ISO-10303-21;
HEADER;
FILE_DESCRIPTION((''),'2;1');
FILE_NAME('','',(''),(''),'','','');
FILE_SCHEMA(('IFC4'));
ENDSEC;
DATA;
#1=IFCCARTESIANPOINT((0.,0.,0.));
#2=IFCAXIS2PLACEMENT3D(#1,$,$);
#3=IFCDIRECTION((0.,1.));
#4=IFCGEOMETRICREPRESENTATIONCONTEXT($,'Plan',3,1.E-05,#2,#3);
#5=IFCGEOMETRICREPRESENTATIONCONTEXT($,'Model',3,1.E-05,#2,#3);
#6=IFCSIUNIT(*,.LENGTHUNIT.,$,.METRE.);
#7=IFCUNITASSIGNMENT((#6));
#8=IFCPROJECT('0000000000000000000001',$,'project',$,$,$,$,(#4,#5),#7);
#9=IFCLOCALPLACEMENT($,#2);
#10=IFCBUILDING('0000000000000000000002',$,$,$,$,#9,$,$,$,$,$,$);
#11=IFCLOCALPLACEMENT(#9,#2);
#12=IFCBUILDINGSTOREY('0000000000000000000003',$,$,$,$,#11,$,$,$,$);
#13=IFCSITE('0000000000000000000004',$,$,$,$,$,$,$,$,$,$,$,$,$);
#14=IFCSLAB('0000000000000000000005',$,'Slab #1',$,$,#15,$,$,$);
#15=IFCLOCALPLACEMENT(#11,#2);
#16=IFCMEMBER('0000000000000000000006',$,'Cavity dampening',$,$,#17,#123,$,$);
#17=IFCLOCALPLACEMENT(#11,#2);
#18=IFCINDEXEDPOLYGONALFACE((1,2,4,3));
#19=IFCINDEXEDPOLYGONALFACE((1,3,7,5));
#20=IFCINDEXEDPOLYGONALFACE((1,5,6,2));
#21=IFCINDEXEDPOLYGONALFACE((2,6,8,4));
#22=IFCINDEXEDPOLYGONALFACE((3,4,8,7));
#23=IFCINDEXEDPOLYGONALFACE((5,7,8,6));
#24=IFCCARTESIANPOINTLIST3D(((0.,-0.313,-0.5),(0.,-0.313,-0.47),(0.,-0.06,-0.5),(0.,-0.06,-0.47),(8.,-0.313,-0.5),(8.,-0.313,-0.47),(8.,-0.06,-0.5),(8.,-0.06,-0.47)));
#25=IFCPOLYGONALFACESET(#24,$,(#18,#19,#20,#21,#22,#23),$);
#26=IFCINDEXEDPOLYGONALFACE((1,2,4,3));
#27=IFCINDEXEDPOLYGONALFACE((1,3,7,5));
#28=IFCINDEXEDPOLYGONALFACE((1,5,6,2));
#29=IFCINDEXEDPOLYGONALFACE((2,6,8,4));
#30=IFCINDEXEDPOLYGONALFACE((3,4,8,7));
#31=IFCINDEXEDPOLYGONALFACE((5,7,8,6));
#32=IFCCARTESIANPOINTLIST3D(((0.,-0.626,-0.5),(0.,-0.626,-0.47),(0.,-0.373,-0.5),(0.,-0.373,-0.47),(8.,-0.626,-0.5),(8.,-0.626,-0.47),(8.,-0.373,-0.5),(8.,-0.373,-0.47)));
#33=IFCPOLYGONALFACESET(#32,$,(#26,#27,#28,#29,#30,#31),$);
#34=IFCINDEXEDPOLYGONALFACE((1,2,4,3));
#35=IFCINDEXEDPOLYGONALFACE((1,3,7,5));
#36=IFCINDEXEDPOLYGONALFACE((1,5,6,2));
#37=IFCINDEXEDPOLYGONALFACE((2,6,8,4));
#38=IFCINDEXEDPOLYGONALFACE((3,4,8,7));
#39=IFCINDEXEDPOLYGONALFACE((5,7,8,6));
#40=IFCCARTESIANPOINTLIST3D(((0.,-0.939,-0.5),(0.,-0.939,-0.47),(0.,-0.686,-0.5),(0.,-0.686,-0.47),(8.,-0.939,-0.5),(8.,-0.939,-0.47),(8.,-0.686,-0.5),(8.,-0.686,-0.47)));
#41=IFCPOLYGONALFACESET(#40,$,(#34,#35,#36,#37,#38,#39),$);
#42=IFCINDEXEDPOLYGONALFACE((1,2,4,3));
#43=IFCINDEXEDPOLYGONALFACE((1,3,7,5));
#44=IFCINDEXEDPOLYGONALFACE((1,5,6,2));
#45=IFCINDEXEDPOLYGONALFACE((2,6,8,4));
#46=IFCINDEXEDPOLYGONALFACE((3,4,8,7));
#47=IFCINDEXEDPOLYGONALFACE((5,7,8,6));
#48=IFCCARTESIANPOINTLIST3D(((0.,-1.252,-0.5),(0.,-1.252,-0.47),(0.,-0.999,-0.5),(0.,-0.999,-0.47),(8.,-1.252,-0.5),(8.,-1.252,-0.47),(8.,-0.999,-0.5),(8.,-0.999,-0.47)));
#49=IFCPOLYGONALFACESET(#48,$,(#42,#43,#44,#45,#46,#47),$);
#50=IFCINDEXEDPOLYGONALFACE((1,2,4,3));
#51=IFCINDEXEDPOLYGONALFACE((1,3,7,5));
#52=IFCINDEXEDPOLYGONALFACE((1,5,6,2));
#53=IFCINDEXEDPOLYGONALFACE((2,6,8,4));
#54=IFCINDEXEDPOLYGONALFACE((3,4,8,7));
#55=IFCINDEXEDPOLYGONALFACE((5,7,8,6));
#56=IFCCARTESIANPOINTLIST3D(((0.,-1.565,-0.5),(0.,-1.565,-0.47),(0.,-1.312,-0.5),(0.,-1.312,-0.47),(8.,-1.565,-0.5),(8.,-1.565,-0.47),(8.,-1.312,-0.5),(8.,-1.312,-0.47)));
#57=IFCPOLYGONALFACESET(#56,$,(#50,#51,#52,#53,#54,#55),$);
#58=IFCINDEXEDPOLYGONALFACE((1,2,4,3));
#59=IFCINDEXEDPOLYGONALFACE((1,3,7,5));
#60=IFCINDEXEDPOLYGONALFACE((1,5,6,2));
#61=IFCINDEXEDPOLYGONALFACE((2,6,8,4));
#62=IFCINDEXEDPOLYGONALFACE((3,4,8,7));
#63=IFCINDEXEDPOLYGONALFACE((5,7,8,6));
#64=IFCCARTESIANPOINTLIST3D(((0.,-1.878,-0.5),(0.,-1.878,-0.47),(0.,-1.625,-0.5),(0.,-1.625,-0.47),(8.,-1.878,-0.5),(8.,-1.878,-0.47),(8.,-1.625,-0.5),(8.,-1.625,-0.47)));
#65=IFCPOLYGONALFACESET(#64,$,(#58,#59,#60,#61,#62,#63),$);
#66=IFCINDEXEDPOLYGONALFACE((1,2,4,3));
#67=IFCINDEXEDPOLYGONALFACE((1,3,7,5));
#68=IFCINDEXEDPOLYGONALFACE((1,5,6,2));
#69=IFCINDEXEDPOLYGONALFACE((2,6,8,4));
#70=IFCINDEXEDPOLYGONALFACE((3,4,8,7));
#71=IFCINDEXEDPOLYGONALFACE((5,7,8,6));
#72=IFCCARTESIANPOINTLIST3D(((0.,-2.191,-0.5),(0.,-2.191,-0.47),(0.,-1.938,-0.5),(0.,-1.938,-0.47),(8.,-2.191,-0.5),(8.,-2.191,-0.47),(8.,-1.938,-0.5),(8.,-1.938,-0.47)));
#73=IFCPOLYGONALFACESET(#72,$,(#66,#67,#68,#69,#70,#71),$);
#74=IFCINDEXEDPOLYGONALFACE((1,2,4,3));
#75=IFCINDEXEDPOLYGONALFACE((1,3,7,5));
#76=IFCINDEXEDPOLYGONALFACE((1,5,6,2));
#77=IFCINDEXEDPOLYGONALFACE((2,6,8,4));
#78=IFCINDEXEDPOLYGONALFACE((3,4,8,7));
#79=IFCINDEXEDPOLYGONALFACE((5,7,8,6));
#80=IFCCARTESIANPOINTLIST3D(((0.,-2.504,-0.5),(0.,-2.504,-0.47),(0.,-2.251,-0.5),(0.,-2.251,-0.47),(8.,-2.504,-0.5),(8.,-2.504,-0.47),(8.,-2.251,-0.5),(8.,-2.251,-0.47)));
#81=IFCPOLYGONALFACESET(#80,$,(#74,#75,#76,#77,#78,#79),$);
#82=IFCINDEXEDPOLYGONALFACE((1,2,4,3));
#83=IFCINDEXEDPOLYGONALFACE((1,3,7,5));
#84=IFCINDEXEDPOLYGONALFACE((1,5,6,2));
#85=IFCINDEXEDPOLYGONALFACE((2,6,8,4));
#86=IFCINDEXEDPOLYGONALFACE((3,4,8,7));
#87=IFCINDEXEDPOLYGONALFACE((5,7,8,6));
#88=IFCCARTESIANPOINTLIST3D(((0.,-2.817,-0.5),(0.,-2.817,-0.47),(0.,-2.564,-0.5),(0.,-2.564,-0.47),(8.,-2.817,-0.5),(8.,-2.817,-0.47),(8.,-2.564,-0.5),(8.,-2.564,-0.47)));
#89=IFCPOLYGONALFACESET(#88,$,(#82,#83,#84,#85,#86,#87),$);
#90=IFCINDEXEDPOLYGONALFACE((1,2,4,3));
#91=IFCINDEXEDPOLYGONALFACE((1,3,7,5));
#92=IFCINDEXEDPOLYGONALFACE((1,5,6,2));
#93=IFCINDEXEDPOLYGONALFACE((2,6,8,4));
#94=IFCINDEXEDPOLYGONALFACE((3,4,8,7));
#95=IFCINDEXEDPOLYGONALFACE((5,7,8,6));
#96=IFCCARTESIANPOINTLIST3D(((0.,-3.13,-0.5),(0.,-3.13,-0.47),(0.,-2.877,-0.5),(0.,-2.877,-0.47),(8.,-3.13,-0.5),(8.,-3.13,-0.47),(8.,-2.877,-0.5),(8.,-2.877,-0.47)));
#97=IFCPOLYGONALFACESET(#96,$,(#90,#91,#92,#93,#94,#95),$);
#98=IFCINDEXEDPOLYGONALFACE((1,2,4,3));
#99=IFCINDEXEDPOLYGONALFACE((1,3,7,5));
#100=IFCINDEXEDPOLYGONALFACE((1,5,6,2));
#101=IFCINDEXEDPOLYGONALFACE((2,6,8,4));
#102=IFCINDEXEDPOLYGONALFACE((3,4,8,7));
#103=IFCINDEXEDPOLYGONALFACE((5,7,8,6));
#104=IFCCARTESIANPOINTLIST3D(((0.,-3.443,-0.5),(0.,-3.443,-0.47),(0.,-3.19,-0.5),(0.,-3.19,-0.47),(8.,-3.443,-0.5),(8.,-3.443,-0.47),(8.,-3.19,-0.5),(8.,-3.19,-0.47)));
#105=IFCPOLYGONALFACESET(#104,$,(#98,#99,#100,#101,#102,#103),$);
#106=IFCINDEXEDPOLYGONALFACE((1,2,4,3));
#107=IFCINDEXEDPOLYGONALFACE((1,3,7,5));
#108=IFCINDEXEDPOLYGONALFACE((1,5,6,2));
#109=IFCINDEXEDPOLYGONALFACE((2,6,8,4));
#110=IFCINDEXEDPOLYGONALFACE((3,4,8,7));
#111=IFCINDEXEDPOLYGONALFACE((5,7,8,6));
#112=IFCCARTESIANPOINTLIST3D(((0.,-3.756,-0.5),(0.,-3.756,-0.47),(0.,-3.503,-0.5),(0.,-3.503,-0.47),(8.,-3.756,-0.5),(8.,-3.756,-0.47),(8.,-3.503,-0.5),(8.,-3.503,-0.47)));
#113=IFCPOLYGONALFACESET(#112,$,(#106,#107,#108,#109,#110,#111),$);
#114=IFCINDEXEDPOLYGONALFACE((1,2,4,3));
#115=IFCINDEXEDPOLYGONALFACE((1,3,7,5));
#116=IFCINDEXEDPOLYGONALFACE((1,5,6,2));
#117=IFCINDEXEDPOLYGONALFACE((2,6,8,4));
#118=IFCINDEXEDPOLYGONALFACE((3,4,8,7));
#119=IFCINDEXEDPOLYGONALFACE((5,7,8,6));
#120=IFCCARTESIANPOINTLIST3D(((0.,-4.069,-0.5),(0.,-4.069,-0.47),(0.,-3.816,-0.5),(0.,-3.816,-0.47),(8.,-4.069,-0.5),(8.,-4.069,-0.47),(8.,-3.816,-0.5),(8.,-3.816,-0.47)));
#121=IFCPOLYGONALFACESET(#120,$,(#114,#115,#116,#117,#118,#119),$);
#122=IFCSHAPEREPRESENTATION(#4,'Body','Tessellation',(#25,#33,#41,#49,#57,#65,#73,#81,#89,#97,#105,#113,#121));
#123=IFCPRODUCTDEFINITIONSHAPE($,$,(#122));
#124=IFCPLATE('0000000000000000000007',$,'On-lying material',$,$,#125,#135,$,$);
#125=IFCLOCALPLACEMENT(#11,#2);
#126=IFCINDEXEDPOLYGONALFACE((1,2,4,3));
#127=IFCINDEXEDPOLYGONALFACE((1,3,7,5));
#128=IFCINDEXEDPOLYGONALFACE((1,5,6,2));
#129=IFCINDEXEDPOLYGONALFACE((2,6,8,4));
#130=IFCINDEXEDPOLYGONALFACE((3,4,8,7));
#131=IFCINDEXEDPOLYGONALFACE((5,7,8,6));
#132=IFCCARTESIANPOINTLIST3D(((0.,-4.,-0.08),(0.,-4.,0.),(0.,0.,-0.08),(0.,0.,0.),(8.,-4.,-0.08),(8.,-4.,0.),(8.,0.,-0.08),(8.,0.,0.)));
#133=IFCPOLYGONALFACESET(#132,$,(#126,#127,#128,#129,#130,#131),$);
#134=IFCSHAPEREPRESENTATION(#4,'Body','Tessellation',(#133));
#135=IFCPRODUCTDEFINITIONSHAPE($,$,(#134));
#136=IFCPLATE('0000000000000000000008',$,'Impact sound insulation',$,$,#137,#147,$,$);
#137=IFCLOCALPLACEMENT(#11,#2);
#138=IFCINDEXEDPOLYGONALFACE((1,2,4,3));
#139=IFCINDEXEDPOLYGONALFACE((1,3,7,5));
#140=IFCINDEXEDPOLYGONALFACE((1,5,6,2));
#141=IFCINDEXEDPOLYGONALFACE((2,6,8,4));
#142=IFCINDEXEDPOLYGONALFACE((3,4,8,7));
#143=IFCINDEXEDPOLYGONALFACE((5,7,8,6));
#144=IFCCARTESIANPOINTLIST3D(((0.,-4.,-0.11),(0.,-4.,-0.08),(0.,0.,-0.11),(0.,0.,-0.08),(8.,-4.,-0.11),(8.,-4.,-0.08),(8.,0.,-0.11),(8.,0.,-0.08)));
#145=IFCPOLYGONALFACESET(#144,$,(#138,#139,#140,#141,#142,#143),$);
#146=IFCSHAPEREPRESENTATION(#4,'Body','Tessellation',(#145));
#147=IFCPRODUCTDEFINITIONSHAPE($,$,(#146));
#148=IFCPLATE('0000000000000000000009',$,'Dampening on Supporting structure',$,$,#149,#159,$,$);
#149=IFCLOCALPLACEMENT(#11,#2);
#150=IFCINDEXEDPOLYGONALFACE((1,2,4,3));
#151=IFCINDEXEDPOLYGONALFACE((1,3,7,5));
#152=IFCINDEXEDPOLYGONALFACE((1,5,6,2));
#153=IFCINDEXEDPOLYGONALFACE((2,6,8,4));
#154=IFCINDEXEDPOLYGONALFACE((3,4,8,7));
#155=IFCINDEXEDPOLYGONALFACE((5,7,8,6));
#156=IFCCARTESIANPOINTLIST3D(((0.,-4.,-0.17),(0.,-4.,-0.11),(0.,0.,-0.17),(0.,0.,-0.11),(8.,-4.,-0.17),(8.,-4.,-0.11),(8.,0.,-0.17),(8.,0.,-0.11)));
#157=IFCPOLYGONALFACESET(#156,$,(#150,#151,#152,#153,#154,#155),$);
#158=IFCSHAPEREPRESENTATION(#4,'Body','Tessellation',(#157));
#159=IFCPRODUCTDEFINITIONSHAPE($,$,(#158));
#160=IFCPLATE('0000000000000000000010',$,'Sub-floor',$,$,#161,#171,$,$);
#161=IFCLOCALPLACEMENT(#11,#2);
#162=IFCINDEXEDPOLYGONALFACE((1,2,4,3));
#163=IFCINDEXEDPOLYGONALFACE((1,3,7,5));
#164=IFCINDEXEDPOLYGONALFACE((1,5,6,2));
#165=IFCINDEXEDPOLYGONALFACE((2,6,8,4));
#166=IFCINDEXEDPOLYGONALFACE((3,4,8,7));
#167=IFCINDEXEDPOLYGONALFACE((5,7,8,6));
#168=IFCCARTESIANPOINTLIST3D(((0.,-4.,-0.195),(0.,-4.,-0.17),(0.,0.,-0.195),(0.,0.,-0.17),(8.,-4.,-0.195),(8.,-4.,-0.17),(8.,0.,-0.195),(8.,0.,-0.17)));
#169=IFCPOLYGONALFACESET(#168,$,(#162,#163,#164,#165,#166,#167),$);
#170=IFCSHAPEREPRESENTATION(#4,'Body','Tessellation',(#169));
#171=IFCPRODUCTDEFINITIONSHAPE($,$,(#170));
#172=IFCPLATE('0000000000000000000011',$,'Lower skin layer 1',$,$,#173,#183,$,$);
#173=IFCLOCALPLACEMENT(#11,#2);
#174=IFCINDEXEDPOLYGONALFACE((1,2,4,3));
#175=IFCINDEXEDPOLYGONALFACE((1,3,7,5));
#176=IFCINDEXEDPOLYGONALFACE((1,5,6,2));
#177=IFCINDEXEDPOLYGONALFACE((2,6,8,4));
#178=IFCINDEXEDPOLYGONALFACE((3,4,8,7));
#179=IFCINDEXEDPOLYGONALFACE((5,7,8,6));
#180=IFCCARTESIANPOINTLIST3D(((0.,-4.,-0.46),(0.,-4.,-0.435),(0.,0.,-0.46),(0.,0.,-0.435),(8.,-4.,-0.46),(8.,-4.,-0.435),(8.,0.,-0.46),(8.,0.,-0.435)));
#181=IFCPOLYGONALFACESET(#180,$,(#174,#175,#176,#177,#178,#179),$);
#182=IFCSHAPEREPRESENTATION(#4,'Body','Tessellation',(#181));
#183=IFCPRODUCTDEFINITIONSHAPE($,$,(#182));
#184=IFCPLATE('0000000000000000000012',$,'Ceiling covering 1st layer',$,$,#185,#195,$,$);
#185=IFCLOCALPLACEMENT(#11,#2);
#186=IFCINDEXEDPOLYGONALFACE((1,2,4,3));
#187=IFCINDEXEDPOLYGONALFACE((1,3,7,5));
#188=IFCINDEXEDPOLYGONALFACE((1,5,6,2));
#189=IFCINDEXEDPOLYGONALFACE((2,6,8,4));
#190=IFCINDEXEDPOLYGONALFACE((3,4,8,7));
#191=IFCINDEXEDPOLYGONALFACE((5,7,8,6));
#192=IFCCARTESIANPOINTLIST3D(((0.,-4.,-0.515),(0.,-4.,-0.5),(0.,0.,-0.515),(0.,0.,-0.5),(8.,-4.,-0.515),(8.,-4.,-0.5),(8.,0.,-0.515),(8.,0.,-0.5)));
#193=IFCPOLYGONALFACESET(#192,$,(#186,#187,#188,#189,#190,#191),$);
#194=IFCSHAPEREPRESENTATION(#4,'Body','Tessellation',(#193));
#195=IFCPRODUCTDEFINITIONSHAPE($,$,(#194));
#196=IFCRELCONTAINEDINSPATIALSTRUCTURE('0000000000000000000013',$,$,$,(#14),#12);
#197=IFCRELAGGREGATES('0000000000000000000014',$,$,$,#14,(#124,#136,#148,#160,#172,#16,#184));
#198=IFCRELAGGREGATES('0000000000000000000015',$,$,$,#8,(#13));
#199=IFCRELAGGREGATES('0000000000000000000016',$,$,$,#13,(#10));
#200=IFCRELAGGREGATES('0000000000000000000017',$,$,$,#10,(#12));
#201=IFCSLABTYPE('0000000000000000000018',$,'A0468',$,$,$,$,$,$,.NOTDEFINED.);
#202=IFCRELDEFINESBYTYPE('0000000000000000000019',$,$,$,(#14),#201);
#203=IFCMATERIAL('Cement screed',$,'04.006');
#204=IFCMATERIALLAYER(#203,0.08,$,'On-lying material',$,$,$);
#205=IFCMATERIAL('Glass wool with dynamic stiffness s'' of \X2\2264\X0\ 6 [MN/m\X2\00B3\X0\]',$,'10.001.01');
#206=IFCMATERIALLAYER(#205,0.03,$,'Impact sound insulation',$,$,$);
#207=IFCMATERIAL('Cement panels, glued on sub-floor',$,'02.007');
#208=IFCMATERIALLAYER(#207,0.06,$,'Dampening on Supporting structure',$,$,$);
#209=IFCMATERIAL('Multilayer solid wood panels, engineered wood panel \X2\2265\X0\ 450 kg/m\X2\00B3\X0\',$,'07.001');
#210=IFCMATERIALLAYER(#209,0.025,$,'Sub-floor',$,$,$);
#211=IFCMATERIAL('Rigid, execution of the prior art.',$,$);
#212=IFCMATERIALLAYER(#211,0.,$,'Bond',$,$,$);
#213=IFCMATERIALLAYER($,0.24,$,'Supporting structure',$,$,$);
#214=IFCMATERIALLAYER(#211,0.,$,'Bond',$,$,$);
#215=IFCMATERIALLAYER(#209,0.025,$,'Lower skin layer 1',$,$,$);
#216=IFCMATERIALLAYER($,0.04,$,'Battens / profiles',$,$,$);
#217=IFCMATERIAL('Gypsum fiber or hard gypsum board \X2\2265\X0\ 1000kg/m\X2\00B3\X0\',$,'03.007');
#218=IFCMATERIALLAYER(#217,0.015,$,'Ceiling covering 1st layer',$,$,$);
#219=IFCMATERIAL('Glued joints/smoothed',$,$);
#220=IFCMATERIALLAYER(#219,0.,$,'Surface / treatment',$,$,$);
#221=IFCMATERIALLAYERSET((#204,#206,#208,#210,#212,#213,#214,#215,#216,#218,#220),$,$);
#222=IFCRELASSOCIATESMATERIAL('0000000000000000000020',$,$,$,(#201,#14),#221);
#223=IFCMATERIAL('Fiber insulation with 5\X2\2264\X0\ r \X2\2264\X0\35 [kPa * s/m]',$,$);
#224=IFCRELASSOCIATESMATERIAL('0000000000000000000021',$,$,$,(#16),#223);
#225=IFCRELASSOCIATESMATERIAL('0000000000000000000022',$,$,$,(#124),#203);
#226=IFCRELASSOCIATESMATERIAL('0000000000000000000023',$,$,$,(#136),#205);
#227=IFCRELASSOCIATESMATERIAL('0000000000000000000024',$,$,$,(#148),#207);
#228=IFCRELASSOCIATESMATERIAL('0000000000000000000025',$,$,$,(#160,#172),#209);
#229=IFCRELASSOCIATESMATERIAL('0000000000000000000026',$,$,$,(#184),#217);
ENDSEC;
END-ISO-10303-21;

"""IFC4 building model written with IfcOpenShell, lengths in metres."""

from ifc_helpers import new_model, si_unit, direction, frame, frame_2d, origin, origin_with_axes, place, context, project, spatial, rectangle, extrude, material, layer, layer_set, type_object, element, aggregate, save


model = new_model("IFC4")

# Units and contexts
plan_context = context("Plan", 3, precision=1e-05, world=origin(), true_north=direction((0.0, 1.0)))
model_context = context("Model", 3, precision=1e-05, world=origin(), true_north=direction((0.0, 1.0)))
ifc_project = project(units=[si_unit("LENGTHUNIT", "METRE")], contexts=[plan_context, model_context])

# Site, building, storey
site = spatial("IfcSite", under=ifc_project)
building_placement = place(None, origin())
building = spatial("IfcBuilding", under=site, at=building_placement)
storey_placement = place(building_placement, origin())
storey = spatial("IfcBuildingStorey", under=building, at=storey_placement)

# Slab, member, plates
ifc_material_1 = material(Name="Cement screed", Category="04.006")
ifc_layer_1 = layer(ifc_material_1, 0.08, Name="On-lying material")
ifc_material_2 = material(Name="Glass wool with dynamic stiffness s' of ≤ 6 [MN/m³]", Category="10.001.01")
ifc_layer_2 = layer(ifc_material_2, 0.03, Name="Impact sound insulation")
ifc_material_3 = material(Name="Cement panels, glued on sub-floor", Category="02.007")
ifc_layer_3 = layer(ifc_material_3, 0.06, Name="Dampening on Supporting structure")
ifc_material_4 = material(Name="Multilayer solid wood panels, engineered wood panel ≥ 450 kg/m³", Category="07.001")
ifc_layer_4 = layer(ifc_material_4, 0.025, Name="Sub-floor")
ifc_material_5 = material(Name="Rigid, execution of the prior art.")
ifc_layer_5 = layer(ifc_material_5, 0.0, Name="Bond")
ifc_layer_6 = layer(None, 0.24, Name="Supporting structure")
ifc_layer_7 = layer(ifc_material_5, 0.0, Name="Bond")
ifc_layer_8 = layer(ifc_material_4, 0.025, Name="Lower skin layer 1")
ifc_layer_9 = layer(None, 0.04, Name="Battens / profiles")
ifc_material_6 = material(Name="Gypsum fiber or hard gypsum board ≥ 1000kg/m³", Category="03.007")
ifc_layer_10 = layer(ifc_material_6, 0.015, Name="Ceiling covering 1st layer")
ifc_material_7 = material(Name="Glued joints/smoothed")
ifc_layer_11 = layer(ifc_material_7, 0.0, Name="Surface / treatment")
ifc_layer_set = layer_set([ifc_layer_1, ifc_layer_2, ifc_layer_3, ifc_layer_4, ifc_layer_5, ifc_layer_6, ifc_layer_7, ifc_layer_8, ifc_layer_9, ifc_layer_10, ifc_layer_11])
slab_type = type_object("IfcSlabType", Name="A0468", PredefinedType="NOTDEFINED", material=ifc_layer_set)
slab_placement = place(None, frame((0.0, 0.0, 0.0), z_axis=(0.0, 0.0, -1.0), x_axis=(1.0, 0.0, 0.0)))
slab = element("IfcSlab", 1, at=slab_placement, inside=storey, type_object=slab_type, material=ifc_layer_set, Name="Slab #1")
ifc_material_8 = material(Name="Fiber insulation with 5≤ r ≤35 [kPa * s/m]")
member_1_placement = place(slab_placement, origin())
member_1 = element("IfcMember", 2, at=member_1_placement, material=ifc_material_8, Name="Cavity dampening", context=plan_context, shape_type="SweptSolid", body=[
    extrude(rectangle(XDim=0.253, YDim=0.03, at=frame_2d((0.1265, 0.015), x_axis=(1.0, 0.0))), frame((0.0, 0.06, 0.47), z_axis=(1.0, 0.0, 0.0), x_axis=(0.0, 1.0, 0.0)), (0.0, 0.0, 1.0), 8.0),
    extrude(rectangle(XDim=0.253, YDim=0.03, at=frame_2d((0.1265, 0.015), x_axis=(1.0, 0.0))), frame((0.0, 0.373, 0.47), z_axis=(1.0, 0.0, 0.0), x_axis=(0.0, 1.0, 0.0)), (0.0, 0.0, 1.0), 8.0),
    extrude(rectangle(XDim=0.253, YDim=0.03, at=frame_2d((0.1265, 0.015), x_axis=(1.0, 0.0))), frame((0.0, 0.686, 0.47), z_axis=(1.0, 0.0, 0.0), x_axis=(0.0, 1.0, 0.0)), (0.0, 0.0, 1.0), 8.0),
    extrude(rectangle(XDim=0.253, YDim=0.03, at=frame_2d((0.1265, 0.015), x_axis=(1.0, 0.0))), frame((0.0, 0.999, 0.47), z_axis=(1.0, 0.0, 0.0), x_axis=(0.0, 1.0, 0.0)), (0.0, 0.0, 1.0), 8.0),
    extrude(rectangle(XDim=0.253, YDim=0.03, at=frame_2d((0.1265, 0.015), x_axis=(1.0, 0.0))), frame((0.0, 1.312, 0.47), z_axis=(1.0, 0.0, 0.0), x_axis=(0.0, 1.0, 0.0)), (0.0, 0.0, 1.0), 8.0),
    extrude(rectangle(XDim=0.253, YDim=0.03, at=frame_2d((0.1265, 0.015), x_axis=(1.0, 0.0))), frame((0.0, 1.625, 0.47), z_axis=(1.0, 0.0, 0.0), x_axis=(0.0, 1.0, 0.0)), (0.0, 0.0, 1.0), 8.0),
    extrude(rectangle(XDim=0.253, YDim=0.03, at=frame_2d((0.1265, 0.015), x_axis=(1.0, 0.0))), frame((0.0, 1.938, 0.47), z_axis=(1.0, 0.0, 0.0), x_axis=(0.0, 1.0, 0.0)), (0.0, 0.0, 1.0), 8.0),
    extrude(rectangle(XDim=0.253, YDim=0.03, at=frame_2d((0.1265, 0.015), x_axis=(1.0, 0.0))), frame((0.0, 2.251, 0.47), z_axis=(1.0, 0.0, 0.0), x_axis=(0.0, 1.0, 0.0)), (0.0, 0.0, 1.0), 8.0),
    extrude(rectangle(XDim=0.253, YDim=0.03, at=frame_2d((0.1265, 0.015), x_axis=(1.0, 0.0))), frame((0.0, 2.564, 0.47), z_axis=(1.0, 0.0, 0.0), x_axis=(0.0, 1.0, 0.0)), (0.0, 0.0, 1.0), 8.0),
    extrude(rectangle(XDim=0.253, YDim=0.03, at=frame_2d((0.1265, 0.015), x_axis=(1.0, 0.0))), frame((0.0, 2.877, 0.47), z_axis=(1.0, 0.0, 0.0), x_axis=(0.0, 1.0, 0.0)), (0.0, 0.0, 1.0), 8.0),
    extrude(rectangle(XDim=0.253, YDim=0.03, at=frame_2d((0.1265, 0.015), x_axis=(1.0, 0.0))), frame((0.0, 3.19, 0.47), z_axis=(1.0, 0.0, 0.0), x_axis=(0.0, 1.0, 0.0)), (0.0, 0.0, 1.0), 8.0),
    extrude(rectangle(XDim=0.253, YDim=0.03, at=frame_2d((0.1265, 0.015), x_axis=(1.0, 0.0))), frame((0.0, 3.503, 0.47), z_axis=(1.0, 0.0, 0.0), x_axis=(0.0, 1.0, 0.0)), (0.0, 0.0, 1.0), 8.0),
    extrude(rectangle(XDim=0.253, YDim=0.03, at=frame_2d((0.1265, 0.015), x_axis=(1.0, 0.0))), frame((0.0, 3.816, 0.47), z_axis=(1.0, 0.0, 0.0), x_axis=(0.0, 1.0, 0.0)), (0.0, 0.0, 1.0), 8.0),
])
plate_1_placement = place(slab_placement, origin())
plate_1 = element("IfcPlate", 3, at=plate_1_placement, material=ifc_material_1, Name="On-lying material", context=plan_context, shape_type="SweptSolid", body=[
    extrude(rectangle(XDim=8.0, YDim=4.0, at=frame_2d((4.0, 2.0), x_axis=(1.0, 0.0))), origin_with_axes(), (0.0, 0.0, 1.0), 0.08),
])
plate_2_placement = place(slab_placement, origin())
plate_2 = element("IfcPlate", 4, at=plate_2_placement, material=ifc_material_2, Name="Impact sound insulation", context=plan_context, shape_type="SweptSolid", body=[
    extrude(rectangle(XDim=8.0, YDim=4.0, at=frame_2d((4.0, 2.0), x_axis=(1.0, 0.0))), frame((0.0, 0.0, 0.08), z_axis=(0.0, 0.0, 1.0), x_axis=(1.0, 0.0, 0.0)), (0.0, 0.0, 1.0), 0.03),
])
plate_3_placement = place(slab_placement, origin())
plate_3 = element("IfcPlate", 5, at=plate_3_placement, material=ifc_material_3, Name="Dampening on Supporting structure", context=plan_context, shape_type="SweptSolid", body=[
    extrude(rectangle(XDim=8.0, YDim=4.0, at=frame_2d((4.0, 2.0), x_axis=(1.0, 0.0))), frame((0.0, 0.0, 0.11), z_axis=(0.0, 0.0, 1.0), x_axis=(1.0, 0.0, 0.0)), (0.0, 0.0, 1.0), 0.06),
])
plate_4_placement = place(slab_placement, origin())
plate_4 = element("IfcPlate", 6, at=plate_4_placement, material=ifc_material_4, Name="Sub-floor", context=plan_context, shape_type="SweptSolid", body=[
    extrude(rectangle(XDim=8.0, YDim=4.0, at=frame_2d((4.0, 2.0), x_axis=(1.0, 0.0))), frame((0.0, 0.0, 0.17), z_axis=(0.0, 0.0, 1.0), x_axis=(1.0, 0.0, 0.0)), (0.0, 0.0, 1.0), 0.025),
])
plate_5_placement = place(slab_placement, origin())
plate_5 = element("IfcPlate", 7, at=plate_5_placement, material=ifc_material_4, Name="Lower skin layer 1", context=plan_context, shape_type="SweptSolid", body=[
    extrude(rectangle(XDim=8.0, YDim=4.0, at=frame_2d((4.0, 2.0), x_axis=(1.0, 0.0))), frame((0.0, 0.0, 0.435), z_axis=(0.0, 0.0, 1.0), x_axis=(1.0, 0.0, 0.0)), (0.0, 0.0, 1.0), 0.025),
])
plate_6_placement = place(slab_placement, origin())
plate_6 = element("IfcPlate", 8, at=plate_6_placement, material=ifc_material_6, Name="Ceiling covering 1st layer", context=plan_context, shape_type="SweptSolid", body=[
    extrude(rectangle(XDim=8.0, YDim=4.0, at=frame_2d((4.0, 2.0), x_axis=(1.0, 0.0))), frame((0.0, 0.0, 0.5), z_axis=(0.0, 0.0, 1.0), x_axis=(1.0, 0.0, 0.0)), (0.0, 0.0, 1.0), 0.015),
])
aggregate(slab, [plate_1, plate_2, plate_3, plate_4, plate_5, member_1, plate_6])

save(model, "model.ifc")
